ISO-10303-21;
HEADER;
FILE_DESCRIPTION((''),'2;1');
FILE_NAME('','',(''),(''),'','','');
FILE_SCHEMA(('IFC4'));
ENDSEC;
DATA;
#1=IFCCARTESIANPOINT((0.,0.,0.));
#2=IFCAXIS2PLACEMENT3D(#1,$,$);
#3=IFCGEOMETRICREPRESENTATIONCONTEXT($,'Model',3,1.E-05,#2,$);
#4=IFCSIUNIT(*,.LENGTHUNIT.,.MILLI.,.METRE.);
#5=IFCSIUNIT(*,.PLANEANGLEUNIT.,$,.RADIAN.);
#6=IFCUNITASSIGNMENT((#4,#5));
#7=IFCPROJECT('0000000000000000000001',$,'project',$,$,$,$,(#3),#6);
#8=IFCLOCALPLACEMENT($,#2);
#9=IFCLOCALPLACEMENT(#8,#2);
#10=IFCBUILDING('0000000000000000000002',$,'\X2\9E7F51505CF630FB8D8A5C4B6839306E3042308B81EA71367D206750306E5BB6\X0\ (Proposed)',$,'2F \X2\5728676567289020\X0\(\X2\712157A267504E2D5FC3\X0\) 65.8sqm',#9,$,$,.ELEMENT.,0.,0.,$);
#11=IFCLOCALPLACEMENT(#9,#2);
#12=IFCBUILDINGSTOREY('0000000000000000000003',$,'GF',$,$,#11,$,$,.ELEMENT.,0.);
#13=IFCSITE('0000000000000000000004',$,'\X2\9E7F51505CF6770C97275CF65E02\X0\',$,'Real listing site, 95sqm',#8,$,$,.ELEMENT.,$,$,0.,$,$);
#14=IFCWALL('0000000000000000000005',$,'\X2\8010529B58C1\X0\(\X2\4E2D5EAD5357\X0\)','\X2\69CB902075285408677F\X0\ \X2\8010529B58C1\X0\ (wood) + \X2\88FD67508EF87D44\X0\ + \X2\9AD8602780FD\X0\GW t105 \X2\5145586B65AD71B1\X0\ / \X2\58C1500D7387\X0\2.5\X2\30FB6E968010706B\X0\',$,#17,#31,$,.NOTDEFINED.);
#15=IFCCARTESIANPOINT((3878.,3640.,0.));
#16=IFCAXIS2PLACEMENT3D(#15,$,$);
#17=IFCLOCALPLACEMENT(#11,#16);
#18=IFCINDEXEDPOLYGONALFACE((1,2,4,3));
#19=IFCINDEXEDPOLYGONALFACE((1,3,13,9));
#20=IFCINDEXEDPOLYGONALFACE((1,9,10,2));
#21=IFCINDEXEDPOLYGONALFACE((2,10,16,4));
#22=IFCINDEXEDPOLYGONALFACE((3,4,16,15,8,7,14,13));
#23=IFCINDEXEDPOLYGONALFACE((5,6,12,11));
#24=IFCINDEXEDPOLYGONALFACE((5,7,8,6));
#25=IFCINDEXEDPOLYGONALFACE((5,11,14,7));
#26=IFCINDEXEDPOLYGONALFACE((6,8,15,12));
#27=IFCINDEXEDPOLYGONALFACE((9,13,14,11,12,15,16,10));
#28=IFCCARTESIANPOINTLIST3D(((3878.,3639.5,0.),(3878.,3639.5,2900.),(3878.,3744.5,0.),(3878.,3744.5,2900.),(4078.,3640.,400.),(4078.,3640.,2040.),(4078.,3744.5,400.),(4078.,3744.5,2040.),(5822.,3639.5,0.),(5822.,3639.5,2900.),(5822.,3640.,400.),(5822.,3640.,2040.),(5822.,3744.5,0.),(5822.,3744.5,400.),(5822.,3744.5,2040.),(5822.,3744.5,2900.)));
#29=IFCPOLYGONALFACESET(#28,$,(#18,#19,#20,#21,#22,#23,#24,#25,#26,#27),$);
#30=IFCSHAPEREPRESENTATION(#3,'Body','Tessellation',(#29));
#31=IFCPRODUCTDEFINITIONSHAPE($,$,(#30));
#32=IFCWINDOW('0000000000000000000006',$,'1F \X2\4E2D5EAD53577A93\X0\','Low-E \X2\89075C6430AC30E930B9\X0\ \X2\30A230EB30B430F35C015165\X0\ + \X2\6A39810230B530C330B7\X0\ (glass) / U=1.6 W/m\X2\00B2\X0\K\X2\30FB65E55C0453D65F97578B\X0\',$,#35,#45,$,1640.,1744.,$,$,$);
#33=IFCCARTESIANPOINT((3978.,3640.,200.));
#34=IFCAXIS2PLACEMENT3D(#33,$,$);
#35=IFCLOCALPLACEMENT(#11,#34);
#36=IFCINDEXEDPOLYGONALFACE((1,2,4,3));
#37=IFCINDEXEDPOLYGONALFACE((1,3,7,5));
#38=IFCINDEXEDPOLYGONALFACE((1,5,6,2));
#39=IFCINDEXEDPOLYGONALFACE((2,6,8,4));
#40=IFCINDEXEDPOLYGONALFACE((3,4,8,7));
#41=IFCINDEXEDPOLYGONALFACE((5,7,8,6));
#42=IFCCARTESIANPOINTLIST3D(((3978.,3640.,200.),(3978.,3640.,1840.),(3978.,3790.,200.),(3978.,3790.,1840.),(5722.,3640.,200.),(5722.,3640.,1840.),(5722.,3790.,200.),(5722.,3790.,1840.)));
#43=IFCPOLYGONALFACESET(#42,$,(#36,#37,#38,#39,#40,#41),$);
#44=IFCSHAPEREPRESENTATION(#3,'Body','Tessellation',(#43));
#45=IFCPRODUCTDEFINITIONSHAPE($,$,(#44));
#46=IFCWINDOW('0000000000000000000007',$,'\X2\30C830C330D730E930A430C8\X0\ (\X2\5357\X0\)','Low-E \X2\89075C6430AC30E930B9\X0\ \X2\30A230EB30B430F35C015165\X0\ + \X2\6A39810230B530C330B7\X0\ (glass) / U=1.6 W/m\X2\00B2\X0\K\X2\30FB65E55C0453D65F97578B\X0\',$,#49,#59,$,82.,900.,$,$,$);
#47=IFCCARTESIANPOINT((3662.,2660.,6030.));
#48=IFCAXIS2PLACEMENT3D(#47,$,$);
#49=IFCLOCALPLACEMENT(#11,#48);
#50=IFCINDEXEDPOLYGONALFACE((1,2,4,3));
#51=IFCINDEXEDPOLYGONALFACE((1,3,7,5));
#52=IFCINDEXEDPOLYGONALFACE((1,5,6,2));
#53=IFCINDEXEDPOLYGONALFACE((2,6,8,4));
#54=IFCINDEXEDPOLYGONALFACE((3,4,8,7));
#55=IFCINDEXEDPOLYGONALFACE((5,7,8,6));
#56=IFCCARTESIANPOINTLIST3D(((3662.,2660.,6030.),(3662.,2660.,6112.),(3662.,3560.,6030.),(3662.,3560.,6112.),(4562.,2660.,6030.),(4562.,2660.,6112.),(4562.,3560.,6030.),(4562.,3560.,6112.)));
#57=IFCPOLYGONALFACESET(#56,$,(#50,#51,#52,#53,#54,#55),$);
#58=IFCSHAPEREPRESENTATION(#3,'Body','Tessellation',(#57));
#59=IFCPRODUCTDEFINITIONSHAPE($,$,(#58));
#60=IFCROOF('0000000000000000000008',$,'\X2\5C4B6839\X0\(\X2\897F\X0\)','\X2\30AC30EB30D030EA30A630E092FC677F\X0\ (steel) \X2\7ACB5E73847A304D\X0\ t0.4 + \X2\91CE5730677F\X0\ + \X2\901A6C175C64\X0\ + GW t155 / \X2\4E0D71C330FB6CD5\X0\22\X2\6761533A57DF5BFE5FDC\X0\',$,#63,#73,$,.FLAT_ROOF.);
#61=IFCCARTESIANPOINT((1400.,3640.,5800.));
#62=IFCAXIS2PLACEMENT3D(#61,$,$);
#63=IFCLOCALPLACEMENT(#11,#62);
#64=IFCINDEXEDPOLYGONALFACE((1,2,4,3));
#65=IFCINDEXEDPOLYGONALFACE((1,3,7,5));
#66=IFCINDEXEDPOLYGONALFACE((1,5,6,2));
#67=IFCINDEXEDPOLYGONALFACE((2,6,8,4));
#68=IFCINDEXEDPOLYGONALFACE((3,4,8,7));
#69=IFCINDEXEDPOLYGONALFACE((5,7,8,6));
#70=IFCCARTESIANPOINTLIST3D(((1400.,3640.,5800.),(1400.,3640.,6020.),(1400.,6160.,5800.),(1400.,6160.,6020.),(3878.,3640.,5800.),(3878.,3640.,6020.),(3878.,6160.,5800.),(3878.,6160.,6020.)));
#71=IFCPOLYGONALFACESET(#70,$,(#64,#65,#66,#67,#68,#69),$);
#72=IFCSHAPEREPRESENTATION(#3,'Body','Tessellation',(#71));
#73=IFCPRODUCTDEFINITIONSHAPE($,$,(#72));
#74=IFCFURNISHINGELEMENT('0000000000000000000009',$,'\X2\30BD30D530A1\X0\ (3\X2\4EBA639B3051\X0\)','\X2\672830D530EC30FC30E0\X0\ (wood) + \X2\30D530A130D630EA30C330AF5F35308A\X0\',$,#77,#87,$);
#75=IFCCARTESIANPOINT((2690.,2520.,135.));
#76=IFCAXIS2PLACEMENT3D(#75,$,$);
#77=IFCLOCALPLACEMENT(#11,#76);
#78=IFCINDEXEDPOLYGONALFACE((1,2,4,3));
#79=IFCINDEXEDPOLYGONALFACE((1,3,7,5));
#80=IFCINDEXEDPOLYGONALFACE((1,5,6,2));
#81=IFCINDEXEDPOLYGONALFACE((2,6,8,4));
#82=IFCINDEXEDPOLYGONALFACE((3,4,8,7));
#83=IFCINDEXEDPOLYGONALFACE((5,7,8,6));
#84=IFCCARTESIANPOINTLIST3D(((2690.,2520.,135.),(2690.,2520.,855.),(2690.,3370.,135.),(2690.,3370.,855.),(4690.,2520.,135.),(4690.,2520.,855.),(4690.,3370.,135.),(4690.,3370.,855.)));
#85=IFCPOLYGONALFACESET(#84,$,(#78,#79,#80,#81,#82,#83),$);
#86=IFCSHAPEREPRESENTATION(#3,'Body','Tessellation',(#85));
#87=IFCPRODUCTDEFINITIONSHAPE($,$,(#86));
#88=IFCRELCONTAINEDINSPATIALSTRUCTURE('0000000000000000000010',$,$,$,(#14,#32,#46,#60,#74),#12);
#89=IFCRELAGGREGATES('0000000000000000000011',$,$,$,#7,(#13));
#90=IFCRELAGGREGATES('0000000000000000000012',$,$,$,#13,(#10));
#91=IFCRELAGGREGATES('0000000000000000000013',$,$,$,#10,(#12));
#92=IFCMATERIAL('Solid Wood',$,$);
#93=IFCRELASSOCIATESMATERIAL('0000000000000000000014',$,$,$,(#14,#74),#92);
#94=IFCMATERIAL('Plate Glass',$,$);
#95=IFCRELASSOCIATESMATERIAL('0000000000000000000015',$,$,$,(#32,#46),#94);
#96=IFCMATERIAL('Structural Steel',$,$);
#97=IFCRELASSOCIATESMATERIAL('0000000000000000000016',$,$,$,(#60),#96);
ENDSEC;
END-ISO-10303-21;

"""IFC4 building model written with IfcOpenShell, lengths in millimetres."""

from ifc_helpers import new_model, si_unit, frame, frame_2d, origin, place, context, project, spatial, rectangle, extrude, material, element, fill, save


model = new_model("IFC4")

# Units and contexts
model_context = context("Model", 3, precision=1e-05, world=origin())
ifc_project = project(units=[si_unit("LENGTHUNIT", "METRE", prefix="MILLI"), si_unit("PLANEANGLEUNIT", "RADIAN")], contexts=[model_context])

# Site, building, storey
site_placement = place(None, origin())
site = spatial("IfcSite", under=ifc_project, at=site_placement, Name="鹿児島県霧島市", ObjectType="Real listing site, 95sqm", CompositionType="ELEMENT", RefElevation=0.0)
building_placement = place(site_placement, origin())
building = spatial("IfcBuilding", under=site, at=building_placement, Name="鹿児島・越屋根のある自然素材の家 (Proposed)", ObjectType="2F 在来木造(無垢材中心) 65.8sqm", CompositionType="ELEMENT", ElevationOfRefHeight=0.0, ElevationOfTerrain=0.0)
storey_placement = place(building_placement, origin())
storey = spatial("IfcBuildingStorey", under=building, at=storey_placement, Name="GF", CompositionType="ELEMENT", Elevation=0.0)

# Shared definitions
ifc_material_1 = material(Name="Solid Wood")

# Wall, opening, window
wall_placement = place(storey_placement, frame((3878.0, 3640.0, 0.0)))
wall = element("IfcWall", 1, at=wall_placement, inside=storey, material=ifc_material_1, Name="耐力壁(中庭南)", Description="構造用合板 耐力壁 (wood) + 製材軸組 + 高性能GW t105 充填断熱 / 壁倍率2.5・準耐火", PredefinedType="NOTDEFINED", context=model_context, shape_type="SweptSolid", body=[
    extrude(rectangle(XDim=1944.0, YDim=105.0, at=frame_2d((972.0, 52.0))), frame((3878.0, 3640.0, 0.0)), (0.0, 0.0, 1.0), 2900.0),
])
opening_placement = place(storey_placement, frame((3978.0, 3640.0, 200.0)))
opening = element("IfcOpeningElement", 2, at=opening_placement, cuts=wall, PredefinedType="NOTDEFINED", context=model_context, shape_type="SweptSolid", body=[
    extrude(rectangle(XDim=1744.0, YDim=150.0, at=frame_2d((872.0, 75.0))), frame((3978.0, 3640.0, 200.0)), (0.0, 0.0, 1.0), 1640.0),
])
ifc_material_2 = material(Name="Plate Glass")
window_1_placement = place(storey_placement, frame((3978.0, 3640.0, 200.0)))
window_1 = element("IfcWindow", 3, at=window_1_placement, inside=storey, material=ifc_material_2, Name="1F 中庭南窓", Description="Low-E 複層ガラス アルゴン封入 + 樹脂サッシ (glass) / U=1.6 W/m²K・日射取得型", OverallHeight=1640.0, OverallWidth=1744.0, context=model_context, shape_type="SweptSolid", body=[
    extrude(rectangle(XDim=1744.0, YDim=150.0, at=frame_2d((872.0, 75.0))), frame((3978.0, 3640.0, 200.0)), (0.0, 0.0, 1.0), 1640.0),
])
fill(opening, window_1)

# Window
window_2_placement = place(storey_placement, frame((3662.0, 2660.0, 6030.0)))
element("IfcWindow", 4, at=window_2_placement, inside=storey, material=ifc_material_2, Name="トップライト (南)", Description="Low-E 複層ガラス アルゴン封入 + 樹脂サッシ (glass) / U=1.6 W/m²K・日射取得型", OverallHeight=82.0, OverallWidth=900.0, context=model_context, shape_type="SweptSolid", body=[
    extrude(rectangle(XDim=900.0, YDim=900.0, at=frame_2d((450.0, 450.0))), frame((3662.0, 2660.0, 6030.0)), (0.0, 0.0, 1.0), 82.0),
])

# Roof
ifc_material_3 = material(Name="Structural Steel")
for number, where, name in (
    (5, (1400.0, 3640.0, 5800.0), "屋根(西)"),
):
    element("IfcRoof", number, at=place(storey_placement, frame(where)), inside=storey, material=ifc_material_3, Name=name, Description="ガルバリウム鋼板 (steel) 立平葺き t0.4 + 野地板 + 通気層 + GW t155 / 不燃・法22条区域対応", PredefinedType="FLAT_ROOF", context=model_context, shape_type="SweptSolid", body=[
        extrude(rectangle(XDim=2478.0, YDim=2520.0, at=frame_2d((1239.0, 1260.0))), frame((1400.0, 3640.0, 5800.0)), (0.0, 0.0, 1.0), 220.0),
    ])

# Furnishing element
furnishing_placement = place(storey_placement, frame((2690.0, 2520.0, 135.0)))
element("IfcFurnishingElement", 6, at=furnishing_placement, inside=storey, material=ifc_material_1, Name="ソファ (3人掛け)", Description="木フレーム (wood) + ファブリック張り", context=model_context, shape_type="SweptSolid", body=[
    extrude(rectangle(XDim=2000.0, YDim=850.0, at=frame_2d((1000.0, 425.0))), frame((2690.0, 2520.0, 135.0)), (0.0, 0.0, 1.0), 720.0),
])

save(model, "model.ifc")
